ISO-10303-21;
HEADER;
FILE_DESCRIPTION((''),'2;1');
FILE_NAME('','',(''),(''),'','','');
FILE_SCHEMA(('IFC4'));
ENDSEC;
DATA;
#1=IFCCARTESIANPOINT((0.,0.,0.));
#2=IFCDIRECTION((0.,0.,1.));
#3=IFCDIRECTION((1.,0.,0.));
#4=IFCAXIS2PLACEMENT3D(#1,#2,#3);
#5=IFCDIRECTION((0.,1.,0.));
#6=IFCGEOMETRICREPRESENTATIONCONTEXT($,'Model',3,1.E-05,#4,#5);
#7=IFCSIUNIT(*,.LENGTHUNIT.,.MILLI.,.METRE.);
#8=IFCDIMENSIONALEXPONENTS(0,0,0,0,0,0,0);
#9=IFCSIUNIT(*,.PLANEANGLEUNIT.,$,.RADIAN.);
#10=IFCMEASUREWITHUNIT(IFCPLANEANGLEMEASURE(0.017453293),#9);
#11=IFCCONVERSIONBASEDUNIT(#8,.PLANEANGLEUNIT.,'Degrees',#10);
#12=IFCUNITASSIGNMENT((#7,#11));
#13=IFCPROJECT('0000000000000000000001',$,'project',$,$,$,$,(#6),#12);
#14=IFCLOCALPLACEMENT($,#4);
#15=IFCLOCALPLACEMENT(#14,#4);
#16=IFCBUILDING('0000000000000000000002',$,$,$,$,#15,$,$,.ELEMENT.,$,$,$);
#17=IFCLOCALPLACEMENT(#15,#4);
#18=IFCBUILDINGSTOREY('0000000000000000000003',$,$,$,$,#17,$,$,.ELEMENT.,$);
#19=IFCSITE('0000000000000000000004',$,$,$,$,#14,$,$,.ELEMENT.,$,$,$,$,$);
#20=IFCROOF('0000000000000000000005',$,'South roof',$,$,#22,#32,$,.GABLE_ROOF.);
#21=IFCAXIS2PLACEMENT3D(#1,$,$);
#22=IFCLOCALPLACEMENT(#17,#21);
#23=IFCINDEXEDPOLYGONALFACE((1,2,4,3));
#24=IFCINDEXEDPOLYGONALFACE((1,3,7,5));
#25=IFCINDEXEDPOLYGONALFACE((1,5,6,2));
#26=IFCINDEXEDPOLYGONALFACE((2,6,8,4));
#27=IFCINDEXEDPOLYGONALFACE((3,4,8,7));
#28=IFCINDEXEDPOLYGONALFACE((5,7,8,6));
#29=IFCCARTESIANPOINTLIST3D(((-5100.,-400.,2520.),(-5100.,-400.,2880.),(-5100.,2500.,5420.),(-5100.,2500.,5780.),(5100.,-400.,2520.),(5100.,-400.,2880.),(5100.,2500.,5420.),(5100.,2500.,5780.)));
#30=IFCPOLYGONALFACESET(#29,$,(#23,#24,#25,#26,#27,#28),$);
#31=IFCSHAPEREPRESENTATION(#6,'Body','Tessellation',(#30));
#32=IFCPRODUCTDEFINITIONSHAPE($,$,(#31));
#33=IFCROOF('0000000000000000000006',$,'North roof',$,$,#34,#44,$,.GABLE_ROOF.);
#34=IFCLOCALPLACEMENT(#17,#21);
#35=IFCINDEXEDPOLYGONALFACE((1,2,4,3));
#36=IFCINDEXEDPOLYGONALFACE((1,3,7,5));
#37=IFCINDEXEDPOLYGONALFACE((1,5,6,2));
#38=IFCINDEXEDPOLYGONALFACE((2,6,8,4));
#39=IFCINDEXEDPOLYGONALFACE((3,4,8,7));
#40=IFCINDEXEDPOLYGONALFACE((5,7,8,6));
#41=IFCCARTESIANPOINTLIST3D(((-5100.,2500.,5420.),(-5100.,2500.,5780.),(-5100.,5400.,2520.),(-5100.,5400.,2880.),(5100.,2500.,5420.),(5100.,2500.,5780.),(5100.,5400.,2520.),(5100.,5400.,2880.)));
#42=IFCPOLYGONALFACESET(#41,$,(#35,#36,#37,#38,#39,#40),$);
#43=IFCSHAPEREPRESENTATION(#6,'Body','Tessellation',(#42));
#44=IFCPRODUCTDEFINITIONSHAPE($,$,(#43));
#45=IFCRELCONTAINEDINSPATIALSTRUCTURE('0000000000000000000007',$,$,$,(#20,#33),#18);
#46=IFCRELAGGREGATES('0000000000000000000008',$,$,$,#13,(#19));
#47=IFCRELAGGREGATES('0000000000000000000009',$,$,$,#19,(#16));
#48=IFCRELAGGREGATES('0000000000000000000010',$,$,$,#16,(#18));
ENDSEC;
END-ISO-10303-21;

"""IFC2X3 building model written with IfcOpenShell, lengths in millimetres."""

from ifc_helpers import new_model, entity, si_unit, converted_unit, direction, frame, origin_with_axes, place, context, project, spatial, polyline, outline, extrude, element, save


model = new_model("IFC2X3")

# Units and contexts
model_context = context("Model", 3, precision=1e-05, world=origin_with_axes(), true_north=direction((0.0, 1.0, 0.0)))
ifc_project = project(units=[si_unit("LENGTHUNIT", "METRE", prefix="MILLI"), converted_unit("PLANEANGLEUNIT", "Degrees", entity("IfcPlaneAngleMeasure", 0.017453293), si_unit("PLANEANGLEUNIT", "RADIAN"), dimensions=[0, 0, 0, 0, 0, 0, 0])], contexts=[model_context])

# Site, building, storey
site_placement = place(None, origin_with_axes())
site = spatial("IfcSite", under=ifc_project, at=site_placement, CompositionType="ELEMENT")
building_placement = place(site_placement, origin_with_axes())
building = spatial("IfcBuilding", under=site, at=building_placement, CompositionType="ELEMENT")
storey_placement = place(building_placement, origin_with_axes())
storey = spatial("IfcBuildingStorey", under=building, at=storey_placement, CompositionType="ELEMENT")

# Roofs
for number, where, z_axis, x_axis, name in (
    (1, (0.0, -400.0, 2700.0), (0.0, 0.0, 1.0), (1.0, 0.0, 0.0), "South roof"),
    (2, (0.0, 5400.0, 2700.0), (0.0, 0.0, 1.0), (-1.0, 0.0, 0.0), "North roof"),
):
    element("IfcRoof", number, at=place(storey_placement, frame(where, z_axis=z_axis, x_axis=x_axis)), inside=storey, Name=name, ShapeType="GABLE_ROOF", context=model_context, shape_type="SweptSolid", body=[
        extrude(outline(polyline([(-5100.0, -180.0), (5100.0, -180.0), (5100.0, 180.0), (-5100.0, 180.0), (-5100.0, -180.0)])), frame((0.0, 0.0, 0.0), z_axis=(0.0, 1.0, 0.0), x_axis=(1.0, 0.0, 0.0)), (0.0, -0.707107, 0.707107), 4101.2),
    ])

save(model, "model.ifc")
